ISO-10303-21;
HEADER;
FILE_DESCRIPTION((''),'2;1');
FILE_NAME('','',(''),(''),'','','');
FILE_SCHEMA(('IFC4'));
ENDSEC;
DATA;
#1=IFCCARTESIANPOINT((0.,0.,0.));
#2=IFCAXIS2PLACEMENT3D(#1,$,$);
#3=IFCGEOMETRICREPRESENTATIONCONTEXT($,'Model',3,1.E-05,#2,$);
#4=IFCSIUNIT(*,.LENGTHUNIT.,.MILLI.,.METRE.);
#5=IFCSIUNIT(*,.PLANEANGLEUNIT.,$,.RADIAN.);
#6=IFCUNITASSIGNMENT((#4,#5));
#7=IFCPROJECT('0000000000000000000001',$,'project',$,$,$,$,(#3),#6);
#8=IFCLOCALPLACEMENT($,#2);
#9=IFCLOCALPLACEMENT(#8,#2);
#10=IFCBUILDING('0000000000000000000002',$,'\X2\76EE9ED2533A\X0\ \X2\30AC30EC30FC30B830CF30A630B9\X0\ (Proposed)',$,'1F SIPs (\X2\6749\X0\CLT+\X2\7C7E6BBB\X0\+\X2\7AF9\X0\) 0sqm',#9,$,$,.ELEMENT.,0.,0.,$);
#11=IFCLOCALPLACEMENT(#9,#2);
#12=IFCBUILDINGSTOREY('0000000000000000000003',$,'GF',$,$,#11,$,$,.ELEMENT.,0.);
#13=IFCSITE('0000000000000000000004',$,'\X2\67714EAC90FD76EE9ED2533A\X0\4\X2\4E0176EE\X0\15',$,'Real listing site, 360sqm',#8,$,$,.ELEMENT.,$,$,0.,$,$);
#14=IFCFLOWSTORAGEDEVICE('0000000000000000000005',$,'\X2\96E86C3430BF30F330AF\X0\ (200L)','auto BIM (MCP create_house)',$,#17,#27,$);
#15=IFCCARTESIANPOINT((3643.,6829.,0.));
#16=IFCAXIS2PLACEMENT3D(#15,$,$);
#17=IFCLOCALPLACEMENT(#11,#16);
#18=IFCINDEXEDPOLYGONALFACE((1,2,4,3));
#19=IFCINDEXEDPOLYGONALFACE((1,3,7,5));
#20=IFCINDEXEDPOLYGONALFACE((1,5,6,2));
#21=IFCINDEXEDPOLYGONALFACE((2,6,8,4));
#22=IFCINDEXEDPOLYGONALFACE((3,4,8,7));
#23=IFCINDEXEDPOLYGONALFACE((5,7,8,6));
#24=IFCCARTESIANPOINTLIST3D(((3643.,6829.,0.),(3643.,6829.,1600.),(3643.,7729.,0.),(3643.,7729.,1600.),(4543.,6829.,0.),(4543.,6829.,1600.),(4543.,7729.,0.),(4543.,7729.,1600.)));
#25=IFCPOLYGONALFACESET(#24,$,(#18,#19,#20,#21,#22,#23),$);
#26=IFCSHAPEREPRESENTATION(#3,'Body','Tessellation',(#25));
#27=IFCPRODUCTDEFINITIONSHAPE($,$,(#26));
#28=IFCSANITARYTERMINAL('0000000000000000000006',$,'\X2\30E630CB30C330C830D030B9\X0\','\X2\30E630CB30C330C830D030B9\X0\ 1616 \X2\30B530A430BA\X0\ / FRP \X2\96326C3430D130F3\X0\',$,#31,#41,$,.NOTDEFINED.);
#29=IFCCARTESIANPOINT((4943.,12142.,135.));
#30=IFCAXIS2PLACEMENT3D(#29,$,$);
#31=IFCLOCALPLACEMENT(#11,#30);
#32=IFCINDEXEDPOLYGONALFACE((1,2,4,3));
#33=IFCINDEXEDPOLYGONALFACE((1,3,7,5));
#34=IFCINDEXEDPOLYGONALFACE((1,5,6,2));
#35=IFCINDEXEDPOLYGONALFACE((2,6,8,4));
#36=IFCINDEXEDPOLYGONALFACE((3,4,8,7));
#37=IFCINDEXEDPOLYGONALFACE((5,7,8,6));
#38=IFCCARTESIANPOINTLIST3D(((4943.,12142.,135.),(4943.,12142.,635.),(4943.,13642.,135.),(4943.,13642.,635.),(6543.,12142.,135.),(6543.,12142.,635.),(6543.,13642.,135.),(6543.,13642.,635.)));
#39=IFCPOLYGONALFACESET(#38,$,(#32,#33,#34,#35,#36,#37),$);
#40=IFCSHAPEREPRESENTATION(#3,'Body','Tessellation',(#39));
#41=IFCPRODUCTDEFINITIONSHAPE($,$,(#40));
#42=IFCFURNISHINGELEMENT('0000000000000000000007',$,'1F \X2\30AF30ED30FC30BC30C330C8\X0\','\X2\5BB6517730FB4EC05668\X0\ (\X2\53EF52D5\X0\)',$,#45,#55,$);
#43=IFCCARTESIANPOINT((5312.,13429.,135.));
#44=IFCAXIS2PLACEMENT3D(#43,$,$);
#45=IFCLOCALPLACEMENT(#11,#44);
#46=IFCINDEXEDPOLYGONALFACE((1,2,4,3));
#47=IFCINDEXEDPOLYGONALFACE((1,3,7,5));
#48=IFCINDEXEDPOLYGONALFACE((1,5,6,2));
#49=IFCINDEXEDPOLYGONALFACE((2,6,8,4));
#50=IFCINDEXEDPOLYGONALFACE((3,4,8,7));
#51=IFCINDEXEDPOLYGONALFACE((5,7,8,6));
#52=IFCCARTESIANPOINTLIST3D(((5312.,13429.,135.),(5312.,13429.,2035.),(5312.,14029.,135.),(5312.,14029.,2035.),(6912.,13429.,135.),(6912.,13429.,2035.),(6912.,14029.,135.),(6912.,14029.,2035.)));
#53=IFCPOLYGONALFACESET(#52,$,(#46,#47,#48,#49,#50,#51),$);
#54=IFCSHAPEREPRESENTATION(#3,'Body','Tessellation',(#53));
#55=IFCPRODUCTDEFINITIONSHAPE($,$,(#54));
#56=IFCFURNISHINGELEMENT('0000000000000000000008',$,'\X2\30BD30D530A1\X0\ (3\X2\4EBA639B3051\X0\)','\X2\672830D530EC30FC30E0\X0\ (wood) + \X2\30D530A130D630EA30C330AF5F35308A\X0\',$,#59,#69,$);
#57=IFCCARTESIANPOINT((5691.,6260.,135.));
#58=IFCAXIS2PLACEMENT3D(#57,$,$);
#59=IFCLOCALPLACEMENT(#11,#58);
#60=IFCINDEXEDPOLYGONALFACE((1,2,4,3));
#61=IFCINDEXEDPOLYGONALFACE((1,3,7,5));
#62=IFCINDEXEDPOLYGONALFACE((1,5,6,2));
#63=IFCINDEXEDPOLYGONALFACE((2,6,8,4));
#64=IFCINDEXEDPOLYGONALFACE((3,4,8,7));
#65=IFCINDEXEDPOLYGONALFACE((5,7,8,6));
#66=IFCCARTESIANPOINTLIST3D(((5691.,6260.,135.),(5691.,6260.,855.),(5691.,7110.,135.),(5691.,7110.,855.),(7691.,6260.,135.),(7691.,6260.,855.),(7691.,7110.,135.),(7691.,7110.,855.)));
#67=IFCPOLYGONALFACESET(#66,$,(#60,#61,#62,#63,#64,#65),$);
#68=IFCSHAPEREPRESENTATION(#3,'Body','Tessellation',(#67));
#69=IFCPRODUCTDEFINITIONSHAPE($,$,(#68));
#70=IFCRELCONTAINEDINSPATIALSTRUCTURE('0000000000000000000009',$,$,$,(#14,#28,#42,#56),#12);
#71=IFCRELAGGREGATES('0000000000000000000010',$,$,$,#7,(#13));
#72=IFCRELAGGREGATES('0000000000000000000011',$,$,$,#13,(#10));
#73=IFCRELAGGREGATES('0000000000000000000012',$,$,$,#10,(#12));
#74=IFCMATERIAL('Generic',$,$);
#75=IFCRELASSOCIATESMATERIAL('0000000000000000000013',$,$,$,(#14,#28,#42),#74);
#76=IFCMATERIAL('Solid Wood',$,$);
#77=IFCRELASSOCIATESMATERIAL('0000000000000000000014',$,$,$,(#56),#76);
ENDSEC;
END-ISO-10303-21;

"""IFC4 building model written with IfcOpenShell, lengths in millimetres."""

from ifc_helpers import new_model, si_unit, frame, frame_2d, origin, place, context, project, spatial, rectangle, extrude, material, element, save


model = new_model("IFC4")

# Units and contexts
model_context = context("Model", 3, precision=1e-05, world=origin())
ifc_project = project(units=[si_unit("LENGTHUNIT", "METRE", prefix="MILLI"), si_unit("PLANEANGLEUNIT", "RADIAN")], contexts=[model_context])

# Site, building, storey
site_placement = place(None, origin())
site = spatial("IfcSite", under=ifc_project, at=site_placement, Name="東京都目黒区4丁目15", ObjectType="Real listing site, 360sqm", CompositionType="ELEMENT", RefElevation=0.0)
building_placement = place(site_placement, origin())
building = spatial("IfcBuilding", under=site, at=building_placement, Name="目黒区 ガレージハウス (Proposed)", ObjectType="1F SIPs (杉CLT+籾殻+竹) 0sqm", CompositionType="ELEMENT", ElevationOfRefHeight=0.0, ElevationOfTerrain=0.0)
storey_placement = place(building_placement, origin())
storey = spatial("IfcBuildingStorey", under=building, at=storey_placement, Name="GF", CompositionType="ELEMENT", Elevation=0.0)

# Shared definitions
ifc_material_1 = material(Name="Solid Wood")

# Shared definitions
ifc_material_2 = material(Name="Generic")

# Flow storage device
flow_storage_device_placement = place(storey_placement, frame((3643.0, 6829.0, 0.0)))
element("IfcFlowStorageDevice", 1, at=flow_storage_device_placement, inside=storey, material=ifc_material_2, Name="雨水タンク (200L)", Description="auto BIM (MCP create_house)", context=model_context, shape_type="SweptSolid", body=[
    extrude(rectangle(XDim=900.0, YDim=900.0, at=frame_2d((450.0, 450.0))), frame((3643.0, 6829.0, 0.0)), (0.0, 0.0, 1.0), 1600.0),
])

# Sanitary terminal
sanitary_terminal_placement = place(storey_placement, frame((4943.0, 12142.0, 135.0)))
element("IfcSanitaryTerminal", 2, at=sanitary_terminal_placement, inside=storey, material=ifc_material_2, Name="ユニットバス", Description="ユニットバス 1616 サイズ / FRP 防水パン", PredefinedType="NOTDEFINED", context=model_context, shape_type="SweptSolid", body=[
    extrude(rectangle(XDim=1600.0, YDim=1500.0, at=frame_2d((800.0, 750.0))), frame((4943.0, 12142.0, 135.0)), (0.0, 0.0, 1.0), 500.0),
])

# Furnishing elements
furnishing_1_placement = place(storey_placement, frame((5312.0, 13429.0, 135.0)))
element("IfcFurnishingElement", 3, at=furnishing_1_placement, inside=storey, material=ifc_material_2, Name="1F クローゼット", Description="家具・什器 (可動)", context=model_context, shape_type="SweptSolid", body=[
    extrude(rectangle(XDim=1600.0, YDim=600.0, at=frame_2d((800.0, 300.0))), frame((5312.0, 13429.0, 135.0)), (0.0, 0.0, 1.0), 1900.0),
])
furnishing_2_placement = place(storey_placement, frame((5691.0, 6260.0, 135.0)))
element("IfcFurnishingElement", 4, at=furnishing_2_placement, inside=storey, material=ifc_material_1, Name="ソファ (3人掛け)", Description="木フレーム (wood) + ファブリック張り", context=model_context, shape_type="SweptSolid", body=[
    extrude(rectangle(XDim=2000.0, YDim=850.0, at=frame_2d((1000.0, 425.0))), frame((5691.0, 6260.0, 135.0)), (0.0, 0.0, 1.0), 720.0),
])

save(model, "model.ifc")
